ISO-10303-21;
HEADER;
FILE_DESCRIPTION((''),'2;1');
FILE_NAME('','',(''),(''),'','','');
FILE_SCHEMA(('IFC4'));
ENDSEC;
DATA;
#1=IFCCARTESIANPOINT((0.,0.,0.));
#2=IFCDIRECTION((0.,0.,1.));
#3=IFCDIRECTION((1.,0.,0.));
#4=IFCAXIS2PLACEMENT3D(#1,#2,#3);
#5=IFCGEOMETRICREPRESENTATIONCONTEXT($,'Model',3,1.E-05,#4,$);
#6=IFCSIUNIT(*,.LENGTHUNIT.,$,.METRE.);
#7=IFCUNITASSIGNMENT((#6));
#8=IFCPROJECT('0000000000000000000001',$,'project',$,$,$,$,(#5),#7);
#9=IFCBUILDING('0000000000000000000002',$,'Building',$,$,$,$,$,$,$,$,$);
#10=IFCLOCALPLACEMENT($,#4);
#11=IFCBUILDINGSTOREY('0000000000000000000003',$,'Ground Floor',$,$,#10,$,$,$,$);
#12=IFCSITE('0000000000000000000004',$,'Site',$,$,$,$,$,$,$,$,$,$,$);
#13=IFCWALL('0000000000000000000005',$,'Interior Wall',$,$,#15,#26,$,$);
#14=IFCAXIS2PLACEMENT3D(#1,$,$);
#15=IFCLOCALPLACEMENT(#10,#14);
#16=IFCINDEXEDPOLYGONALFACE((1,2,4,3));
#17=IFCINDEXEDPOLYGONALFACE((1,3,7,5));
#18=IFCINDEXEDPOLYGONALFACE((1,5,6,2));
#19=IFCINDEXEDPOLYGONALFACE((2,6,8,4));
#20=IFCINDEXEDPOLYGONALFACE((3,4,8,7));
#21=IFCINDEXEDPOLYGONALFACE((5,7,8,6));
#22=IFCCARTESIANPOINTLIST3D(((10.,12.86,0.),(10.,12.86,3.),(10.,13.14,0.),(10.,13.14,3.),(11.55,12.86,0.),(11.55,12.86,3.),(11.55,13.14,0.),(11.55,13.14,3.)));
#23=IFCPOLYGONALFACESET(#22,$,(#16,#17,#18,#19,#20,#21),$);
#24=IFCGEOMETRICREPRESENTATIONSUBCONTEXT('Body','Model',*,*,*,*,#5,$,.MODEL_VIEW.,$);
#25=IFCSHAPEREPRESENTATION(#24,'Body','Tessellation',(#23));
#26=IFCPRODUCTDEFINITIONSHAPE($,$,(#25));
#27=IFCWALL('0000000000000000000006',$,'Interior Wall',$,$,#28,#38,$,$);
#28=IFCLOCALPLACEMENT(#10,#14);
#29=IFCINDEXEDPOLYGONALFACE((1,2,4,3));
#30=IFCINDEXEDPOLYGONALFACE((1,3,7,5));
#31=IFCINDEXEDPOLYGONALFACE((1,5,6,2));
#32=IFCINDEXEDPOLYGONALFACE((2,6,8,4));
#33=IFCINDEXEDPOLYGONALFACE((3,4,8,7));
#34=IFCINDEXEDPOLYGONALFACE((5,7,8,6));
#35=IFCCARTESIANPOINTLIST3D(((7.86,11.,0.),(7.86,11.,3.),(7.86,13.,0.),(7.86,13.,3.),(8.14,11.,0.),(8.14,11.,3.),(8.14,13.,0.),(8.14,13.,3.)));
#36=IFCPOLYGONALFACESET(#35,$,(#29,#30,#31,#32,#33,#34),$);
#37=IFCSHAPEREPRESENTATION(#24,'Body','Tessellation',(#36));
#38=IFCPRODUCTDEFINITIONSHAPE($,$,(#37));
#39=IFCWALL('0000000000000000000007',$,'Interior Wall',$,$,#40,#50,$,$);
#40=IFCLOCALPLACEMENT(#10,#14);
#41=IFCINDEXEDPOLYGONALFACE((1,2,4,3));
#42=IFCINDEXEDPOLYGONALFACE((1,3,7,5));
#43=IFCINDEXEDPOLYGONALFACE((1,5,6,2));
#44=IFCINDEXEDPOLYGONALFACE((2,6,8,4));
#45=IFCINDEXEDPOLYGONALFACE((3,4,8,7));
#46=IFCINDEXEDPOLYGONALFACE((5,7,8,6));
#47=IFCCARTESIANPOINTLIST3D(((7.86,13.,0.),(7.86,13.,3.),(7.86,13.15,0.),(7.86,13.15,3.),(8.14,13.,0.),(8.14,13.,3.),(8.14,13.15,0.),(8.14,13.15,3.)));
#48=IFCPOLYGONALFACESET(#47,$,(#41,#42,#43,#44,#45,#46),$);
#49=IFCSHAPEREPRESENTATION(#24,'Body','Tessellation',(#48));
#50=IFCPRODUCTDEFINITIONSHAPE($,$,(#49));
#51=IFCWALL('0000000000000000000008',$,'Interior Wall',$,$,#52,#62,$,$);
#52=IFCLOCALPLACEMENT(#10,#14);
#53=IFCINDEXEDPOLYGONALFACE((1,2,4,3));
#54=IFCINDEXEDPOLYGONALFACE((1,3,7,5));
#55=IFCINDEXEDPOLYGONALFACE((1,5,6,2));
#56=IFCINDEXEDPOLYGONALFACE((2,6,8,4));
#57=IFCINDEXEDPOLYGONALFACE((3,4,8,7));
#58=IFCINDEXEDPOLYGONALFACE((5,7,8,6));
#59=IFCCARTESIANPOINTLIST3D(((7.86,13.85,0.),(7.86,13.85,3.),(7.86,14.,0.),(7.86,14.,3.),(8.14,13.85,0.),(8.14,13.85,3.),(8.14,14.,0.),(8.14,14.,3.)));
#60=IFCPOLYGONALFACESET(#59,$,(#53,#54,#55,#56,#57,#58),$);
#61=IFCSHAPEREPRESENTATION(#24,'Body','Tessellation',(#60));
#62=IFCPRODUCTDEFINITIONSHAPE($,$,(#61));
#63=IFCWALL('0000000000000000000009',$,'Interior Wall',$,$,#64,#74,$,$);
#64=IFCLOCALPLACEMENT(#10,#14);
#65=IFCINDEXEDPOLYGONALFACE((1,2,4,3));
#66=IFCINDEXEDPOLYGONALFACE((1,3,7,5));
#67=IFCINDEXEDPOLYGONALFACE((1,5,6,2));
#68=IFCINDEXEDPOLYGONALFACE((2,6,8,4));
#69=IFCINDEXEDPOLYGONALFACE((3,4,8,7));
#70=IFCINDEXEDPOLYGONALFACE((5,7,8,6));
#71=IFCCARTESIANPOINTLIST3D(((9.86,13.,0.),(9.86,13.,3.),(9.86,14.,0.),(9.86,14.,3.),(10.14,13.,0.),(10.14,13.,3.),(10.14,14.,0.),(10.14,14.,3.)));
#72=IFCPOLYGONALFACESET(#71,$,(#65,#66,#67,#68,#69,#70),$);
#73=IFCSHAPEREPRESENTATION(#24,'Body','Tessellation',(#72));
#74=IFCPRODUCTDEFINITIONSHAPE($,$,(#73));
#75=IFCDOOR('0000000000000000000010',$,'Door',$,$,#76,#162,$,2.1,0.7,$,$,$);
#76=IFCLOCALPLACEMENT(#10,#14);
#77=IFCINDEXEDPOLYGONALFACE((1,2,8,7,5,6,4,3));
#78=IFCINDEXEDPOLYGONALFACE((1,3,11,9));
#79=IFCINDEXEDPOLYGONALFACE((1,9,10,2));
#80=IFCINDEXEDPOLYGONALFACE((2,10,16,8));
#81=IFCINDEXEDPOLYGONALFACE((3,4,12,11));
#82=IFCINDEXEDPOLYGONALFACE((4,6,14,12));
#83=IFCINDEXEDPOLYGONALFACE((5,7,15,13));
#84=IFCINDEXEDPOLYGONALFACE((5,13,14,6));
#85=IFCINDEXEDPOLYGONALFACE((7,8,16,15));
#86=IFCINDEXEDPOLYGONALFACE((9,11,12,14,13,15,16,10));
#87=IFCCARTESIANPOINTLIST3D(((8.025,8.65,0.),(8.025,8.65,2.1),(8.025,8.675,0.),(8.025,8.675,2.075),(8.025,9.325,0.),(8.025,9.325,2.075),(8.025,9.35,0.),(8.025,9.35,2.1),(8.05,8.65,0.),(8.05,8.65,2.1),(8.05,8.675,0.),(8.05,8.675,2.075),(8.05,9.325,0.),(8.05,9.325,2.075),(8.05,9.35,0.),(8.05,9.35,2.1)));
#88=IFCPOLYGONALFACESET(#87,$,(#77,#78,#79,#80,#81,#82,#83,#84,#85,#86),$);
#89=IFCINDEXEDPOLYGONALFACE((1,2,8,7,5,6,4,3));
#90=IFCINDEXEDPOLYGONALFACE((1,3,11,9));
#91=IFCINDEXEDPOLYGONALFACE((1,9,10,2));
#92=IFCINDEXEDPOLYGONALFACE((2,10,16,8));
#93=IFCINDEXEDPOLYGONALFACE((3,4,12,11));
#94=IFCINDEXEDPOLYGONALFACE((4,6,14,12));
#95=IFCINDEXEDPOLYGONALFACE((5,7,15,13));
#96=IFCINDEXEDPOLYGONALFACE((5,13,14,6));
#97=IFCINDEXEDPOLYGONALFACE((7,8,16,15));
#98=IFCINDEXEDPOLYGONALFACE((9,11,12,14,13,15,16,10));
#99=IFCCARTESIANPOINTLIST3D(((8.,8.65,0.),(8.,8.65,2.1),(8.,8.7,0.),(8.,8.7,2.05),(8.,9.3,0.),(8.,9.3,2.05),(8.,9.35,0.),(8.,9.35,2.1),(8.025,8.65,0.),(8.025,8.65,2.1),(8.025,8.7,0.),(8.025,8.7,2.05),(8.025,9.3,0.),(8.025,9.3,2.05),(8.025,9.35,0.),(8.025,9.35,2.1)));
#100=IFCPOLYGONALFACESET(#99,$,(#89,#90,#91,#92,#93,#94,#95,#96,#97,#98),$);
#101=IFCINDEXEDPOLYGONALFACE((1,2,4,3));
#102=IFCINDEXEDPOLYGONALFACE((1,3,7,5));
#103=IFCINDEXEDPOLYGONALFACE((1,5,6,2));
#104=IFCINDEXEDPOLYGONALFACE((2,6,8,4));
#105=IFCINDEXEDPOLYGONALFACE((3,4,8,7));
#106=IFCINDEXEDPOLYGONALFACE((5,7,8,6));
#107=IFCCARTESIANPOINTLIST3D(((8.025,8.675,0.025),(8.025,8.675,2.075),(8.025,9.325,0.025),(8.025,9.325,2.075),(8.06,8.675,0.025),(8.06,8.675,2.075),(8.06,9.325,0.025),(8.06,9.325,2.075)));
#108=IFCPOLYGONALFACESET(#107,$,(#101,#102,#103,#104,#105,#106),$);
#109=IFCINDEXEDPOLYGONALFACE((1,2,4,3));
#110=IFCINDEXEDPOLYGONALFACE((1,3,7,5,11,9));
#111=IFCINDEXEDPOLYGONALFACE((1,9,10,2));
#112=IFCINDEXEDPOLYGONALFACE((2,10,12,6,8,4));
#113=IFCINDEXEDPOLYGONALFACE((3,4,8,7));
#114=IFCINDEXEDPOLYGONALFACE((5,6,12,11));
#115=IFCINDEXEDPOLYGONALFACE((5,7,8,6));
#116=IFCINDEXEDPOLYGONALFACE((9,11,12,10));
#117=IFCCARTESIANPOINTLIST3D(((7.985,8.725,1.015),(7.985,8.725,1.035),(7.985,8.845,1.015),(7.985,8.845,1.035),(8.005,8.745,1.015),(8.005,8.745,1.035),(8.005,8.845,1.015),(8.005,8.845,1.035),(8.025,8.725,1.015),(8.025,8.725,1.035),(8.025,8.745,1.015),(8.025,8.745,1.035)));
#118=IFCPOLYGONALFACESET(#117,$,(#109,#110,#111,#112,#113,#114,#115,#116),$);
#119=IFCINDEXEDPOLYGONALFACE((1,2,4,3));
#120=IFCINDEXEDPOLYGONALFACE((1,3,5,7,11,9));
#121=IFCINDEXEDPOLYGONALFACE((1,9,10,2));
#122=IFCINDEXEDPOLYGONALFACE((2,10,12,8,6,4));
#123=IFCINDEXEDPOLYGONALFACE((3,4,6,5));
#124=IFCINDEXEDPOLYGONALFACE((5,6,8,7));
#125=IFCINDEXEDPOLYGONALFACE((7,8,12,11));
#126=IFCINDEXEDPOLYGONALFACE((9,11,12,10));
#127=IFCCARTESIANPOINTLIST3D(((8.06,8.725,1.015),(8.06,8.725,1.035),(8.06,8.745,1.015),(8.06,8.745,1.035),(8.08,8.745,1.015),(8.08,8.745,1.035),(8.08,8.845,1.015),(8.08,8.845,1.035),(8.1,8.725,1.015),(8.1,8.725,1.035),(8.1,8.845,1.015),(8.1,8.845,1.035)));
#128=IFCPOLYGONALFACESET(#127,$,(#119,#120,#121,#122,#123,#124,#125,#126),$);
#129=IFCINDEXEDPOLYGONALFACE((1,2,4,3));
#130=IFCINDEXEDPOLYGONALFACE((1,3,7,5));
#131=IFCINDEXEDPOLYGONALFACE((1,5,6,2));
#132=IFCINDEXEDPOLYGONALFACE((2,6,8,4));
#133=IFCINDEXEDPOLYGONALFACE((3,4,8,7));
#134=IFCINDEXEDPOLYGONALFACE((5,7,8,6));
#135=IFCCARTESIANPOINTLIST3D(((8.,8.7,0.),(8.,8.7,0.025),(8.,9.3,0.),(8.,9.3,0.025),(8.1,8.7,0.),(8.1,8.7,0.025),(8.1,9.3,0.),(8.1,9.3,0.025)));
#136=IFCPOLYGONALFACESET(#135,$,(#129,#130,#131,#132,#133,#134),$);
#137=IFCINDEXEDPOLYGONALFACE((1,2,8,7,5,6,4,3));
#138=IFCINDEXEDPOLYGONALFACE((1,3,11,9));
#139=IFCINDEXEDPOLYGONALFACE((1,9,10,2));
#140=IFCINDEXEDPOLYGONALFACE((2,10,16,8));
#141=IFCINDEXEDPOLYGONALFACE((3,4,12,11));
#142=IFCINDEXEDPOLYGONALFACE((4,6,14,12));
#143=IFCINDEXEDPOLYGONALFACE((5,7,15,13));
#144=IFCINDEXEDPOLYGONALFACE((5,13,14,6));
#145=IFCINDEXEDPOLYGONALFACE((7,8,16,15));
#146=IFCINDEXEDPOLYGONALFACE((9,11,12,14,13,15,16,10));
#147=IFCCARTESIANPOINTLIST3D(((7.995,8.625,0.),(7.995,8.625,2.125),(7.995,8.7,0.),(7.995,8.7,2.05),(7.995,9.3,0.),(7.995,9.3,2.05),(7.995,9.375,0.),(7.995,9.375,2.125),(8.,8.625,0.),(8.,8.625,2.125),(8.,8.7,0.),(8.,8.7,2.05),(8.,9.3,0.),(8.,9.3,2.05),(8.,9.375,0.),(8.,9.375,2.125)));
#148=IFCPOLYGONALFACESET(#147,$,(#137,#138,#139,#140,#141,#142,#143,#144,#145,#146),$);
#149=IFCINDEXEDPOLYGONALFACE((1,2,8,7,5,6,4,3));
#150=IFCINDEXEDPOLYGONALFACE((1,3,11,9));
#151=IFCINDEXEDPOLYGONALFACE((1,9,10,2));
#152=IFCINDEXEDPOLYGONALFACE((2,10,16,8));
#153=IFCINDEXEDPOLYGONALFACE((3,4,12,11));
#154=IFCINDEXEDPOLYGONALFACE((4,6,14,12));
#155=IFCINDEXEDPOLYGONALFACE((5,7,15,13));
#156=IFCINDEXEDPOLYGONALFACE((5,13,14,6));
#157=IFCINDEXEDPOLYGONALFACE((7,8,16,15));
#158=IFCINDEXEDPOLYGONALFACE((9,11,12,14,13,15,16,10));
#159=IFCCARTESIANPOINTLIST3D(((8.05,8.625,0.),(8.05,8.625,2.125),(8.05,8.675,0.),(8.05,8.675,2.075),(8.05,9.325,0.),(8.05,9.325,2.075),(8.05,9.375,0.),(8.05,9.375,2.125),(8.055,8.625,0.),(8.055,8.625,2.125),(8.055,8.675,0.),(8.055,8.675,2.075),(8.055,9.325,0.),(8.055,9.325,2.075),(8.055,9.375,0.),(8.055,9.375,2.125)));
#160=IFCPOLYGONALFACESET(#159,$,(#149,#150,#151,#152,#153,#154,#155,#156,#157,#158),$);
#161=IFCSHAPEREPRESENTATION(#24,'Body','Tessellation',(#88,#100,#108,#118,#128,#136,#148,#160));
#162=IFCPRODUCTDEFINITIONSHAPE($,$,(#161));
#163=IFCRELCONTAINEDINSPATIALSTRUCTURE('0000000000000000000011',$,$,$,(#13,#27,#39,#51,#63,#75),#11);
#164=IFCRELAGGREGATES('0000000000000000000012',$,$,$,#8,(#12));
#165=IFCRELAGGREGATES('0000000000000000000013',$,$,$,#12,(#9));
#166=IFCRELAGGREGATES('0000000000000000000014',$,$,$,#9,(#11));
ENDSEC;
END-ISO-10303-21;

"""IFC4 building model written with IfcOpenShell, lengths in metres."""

from ifc_helpers import new_model, si_unit, frame, origin_with_axes, place, context, subcontext, project, spatial, line, indexed_curve, outline, extrude, element, save


model = new_model("IFC4")

# Units and contexts
model_context = context("Model", 3, precision=1e-05, world=origin_with_axes())
body_context = subcontext(model_context, "Body", "Model", "MODEL_VIEW")
ifc_project = project(units=[si_unit("LENGTHUNIT", "METRE")], contexts=[model_context])

# Site, building, storey
site = spatial("IfcSite", under=ifc_project, Name="Site")
building = spatial("IfcBuilding", under=site, Name="Building")
storey_placement = place(None, origin_with_axes())
storey = spatial("IfcBuildingStorey", under=building, at=storey_placement, Name="Ground Floor")

# Walls
for number, where, z_axis, x_axis, name in (
    (1, (11.55, 13.0, 0.0), (0.0, 0.0, 1.0), (-1.0, 0.0, 0.0), "Interior Wall"),
):
    element("IfcWall", number, at=place(storey_placement, frame(where, z_axis=z_axis, x_axis=x_axis)), inside=storey, Name=name, context=body_context, shape_type="SweptSolid", body=[
        extrude(outline(indexed_curve([(0.0, 0.0), (0.0, 0.28), (1.55, 0.28), (1.55, 0.0), (0.0, 0.0)], self_intersect=False)), frame((0.0, -0.14, 0.0), z_axis=(0.0, 0.0, 1.0), x_axis=(1.0, 0.0, 0.0)), (0.0, 0.0, 1.0), 3.0),
    ])
wall_1_placement = place(storey_placement, frame((8.0, 13.0, 0.0), z_axis=(0.0, 0.0, 1.0), x_axis=(0.0, -1.0, 0.0)))
element("IfcWall", 2, at=wall_1_placement, inside=storey, Name="Interior Wall", context=body_context, shape_type="SweptSolid", body=[
    extrude(outline(indexed_curve([(0.0, 0.0), (0.0, 0.28), (2.0, 0.28), (2.0, 0.0), (0.0, 0.0)], self_intersect=False)), frame((0.0, -0.14, 0.0), z_axis=(0.0, 0.0, 1.0), x_axis=(1.0, 0.0, 0.0)), (0.0, 0.0, 1.0), 3.0),
])
for number, where, z_axis, x_axis, name in (
    (3, (8.0, 13.0, 0.0), (0.0, 0.0, 1.0), (0.0, 1.0, 0.0), "Interior Wall"),
    (4, (8.0, 13.85, 0.0), (0.0, 0.0, 1.0), (0.0, 1.0, 0.0), "Interior Wall"),
):
    element("IfcWall", number, at=place(storey_placement, frame(where, z_axis=z_axis, x_axis=x_axis)), inside=storey, Name=name, context=body_context, shape_type="SweptSolid", body=[
        extrude(outline(indexed_curve([(0.0, 0.0), (0.0, 0.28), (0.15, 0.28), (0.15, 0.0), (0.0, 0.0)], self_intersect=False)), frame((0.0, -0.14, 0.0), z_axis=(0.0, 0.0, 1.0), x_axis=(1.0, 0.0, 0.0)), (0.0, 0.0, 1.0), 3.0),
    ])
wall_2_placement = place(storey_placement, frame((10.0, 13.0, 0.0), z_axis=(0.0, 0.0, 1.0), x_axis=(0.0, 1.0, 0.0)))
element("IfcWall", 5, at=wall_2_placement, inside=storey, Name="Interior Wall", context=body_context, shape_type="SweptSolid", body=[
    extrude(outline(indexed_curve([(0.0, 0.0), (0.0, 0.28), (1.0, 0.28), (1.0, 0.0), (0.0, 0.0)], self_intersect=False)), frame((0.0, -0.14, 0.0), z_axis=(0.0, 0.0, 1.0), x_axis=(1.0, 0.0, 0.0)), (0.0, 0.0, 1.0), 3.0),
])

# Door
door_1_placement = place(storey_placement, frame((8.0, 9.35, 0.0), z_axis=(0.0, 0.0, 1.0), x_axis=(0.0, -1.0, 0.0)))
element("IfcDoor", 6, at=door_1_placement, inside=storey, Name="Door", OverallHeight=2.1, OverallWidth=0.7, context=body_context, shape_type="SweptSolid", body=[
    extrude(outline(indexed_curve([(0.0, 0.0), (0.0, 2.1), (0.7, 2.1), (0.7, 0.0), (0.675, 0.0), (0.675, 2.075), (0.025, 2.075), (0.025, 0.0)], segments=[line(1, 2, 3, 4, 5, 6, 7, 8, 1)])), frame((0.0, 0.025, 0.0), z_axis=(0.0, -1.0, 0.0), x_axis=(1.0, 0.0, 0.0)), (0.0, 0.0, -1.0), 0.025),
    extrude(outline(indexed_curve([(0.0, 0.0), (0.0, 2.1), (0.7, 2.1), (0.7, 0.0), (0.65, 0.0), (0.65, 2.05), (0.05, 2.05), (0.05, 0.0)], segments=[line(1, 2, 3, 4, 5, 6, 7, 8, 1)])), frame((0.0, 0.0, 0.0), z_axis=(0.0, -1.0, 0.0), x_axis=(1.0, 0.0, 0.0)), (0.0, 0.0, -1.0), 0.025),
    extrude(outline(indexed_curve([(0.0, 0.0), (0.65, 0.0), (0.65, 0.035), (0.0, 0.035)], segments=[line(1, 2, 3, 4, 1)])), frame((0.025, 0.025, 0.025), z_axis=(0.0, 0.0, 1.0), x_axis=(1.0, 0.0, 0.0)), (0.0, 0.0, 1.0), 2.05),
    extrude(outline(indexed_curve([(0.0, 0.0), (0.0, -0.04), (-0.12, -0.04), (-0.12, -0.02), (-0.02, -0.02), (-0.02, 0.0)], segments=[line(1, 2, 3, 4, 5, 6, 1)])), frame((0.625, 0.025, 1.015), z_axis=(0.0, 0.0, 1.0), x_axis=(1.0, 0.0, 0.0)), (0.0, 0.0, 1.0), 0.02),
    extrude(outline(indexed_curve([(0.0, 0.0), (0.0, 0.04), (-0.12, 0.04), (-0.12, 0.02), (-0.02, 0.02), (-0.02, 0.0)], segments=[line(1, 2, 3, 4, 5, 6, 1)])), frame((0.625, 0.06, 1.015), z_axis=(0.0, 0.0, 1.0), x_axis=(1.0, 0.0, 0.0)), (0.0, 0.0, 1.0), 0.02),
    extrude(outline(indexed_curve([(0.0, 0.0), (0.6, 0.0), (0.6, 0.1), (0.0, 0.1)], segments=[line(1, 2, 3, 4, 1)])), frame((0.05, 0.0, 0.0), z_axis=(0.0, 0.0, 1.0), x_axis=(1.0, 0.0, 0.0)), (0.0, 0.0, 1.0), 0.025),
    extrude(outline(indexed_curve([(0.0, 0.0), (0.0, 2.125), (0.75, 2.125), (0.75, 0.0), (0.675, 0.0), (0.675, 2.05), (0.075, 2.05), (0.075, 0.0)], segments=[line(1, 2, 3, 4, 5, 6, 7, 8, 1)])), frame((-0.025, -0.005, 0.0), z_axis=(0.0, -1.0, 0.0), x_axis=(1.0, 0.0, 0.0)), (0.0, 0.0, -1.0), 0.005),
    extrude(outline(indexed_curve([(0.0, 0.0), (0.0, 2.125), (0.75, 2.125), (0.75, 0.0), (0.7, 0.0), (0.7, 2.075), (0.05, 2.075), (0.05, 0.0)], segments=[line(1, 2, 3, 4, 5, 6, 7, 8, 1)])), frame((-0.025, 0.05, 0.0), z_axis=(0.0, -1.0, 0.0), x_axis=(1.0, 0.0, 0.0)), (0.0, 0.0, -1.0), 0.005),
])

save(model, "model.ifc")
